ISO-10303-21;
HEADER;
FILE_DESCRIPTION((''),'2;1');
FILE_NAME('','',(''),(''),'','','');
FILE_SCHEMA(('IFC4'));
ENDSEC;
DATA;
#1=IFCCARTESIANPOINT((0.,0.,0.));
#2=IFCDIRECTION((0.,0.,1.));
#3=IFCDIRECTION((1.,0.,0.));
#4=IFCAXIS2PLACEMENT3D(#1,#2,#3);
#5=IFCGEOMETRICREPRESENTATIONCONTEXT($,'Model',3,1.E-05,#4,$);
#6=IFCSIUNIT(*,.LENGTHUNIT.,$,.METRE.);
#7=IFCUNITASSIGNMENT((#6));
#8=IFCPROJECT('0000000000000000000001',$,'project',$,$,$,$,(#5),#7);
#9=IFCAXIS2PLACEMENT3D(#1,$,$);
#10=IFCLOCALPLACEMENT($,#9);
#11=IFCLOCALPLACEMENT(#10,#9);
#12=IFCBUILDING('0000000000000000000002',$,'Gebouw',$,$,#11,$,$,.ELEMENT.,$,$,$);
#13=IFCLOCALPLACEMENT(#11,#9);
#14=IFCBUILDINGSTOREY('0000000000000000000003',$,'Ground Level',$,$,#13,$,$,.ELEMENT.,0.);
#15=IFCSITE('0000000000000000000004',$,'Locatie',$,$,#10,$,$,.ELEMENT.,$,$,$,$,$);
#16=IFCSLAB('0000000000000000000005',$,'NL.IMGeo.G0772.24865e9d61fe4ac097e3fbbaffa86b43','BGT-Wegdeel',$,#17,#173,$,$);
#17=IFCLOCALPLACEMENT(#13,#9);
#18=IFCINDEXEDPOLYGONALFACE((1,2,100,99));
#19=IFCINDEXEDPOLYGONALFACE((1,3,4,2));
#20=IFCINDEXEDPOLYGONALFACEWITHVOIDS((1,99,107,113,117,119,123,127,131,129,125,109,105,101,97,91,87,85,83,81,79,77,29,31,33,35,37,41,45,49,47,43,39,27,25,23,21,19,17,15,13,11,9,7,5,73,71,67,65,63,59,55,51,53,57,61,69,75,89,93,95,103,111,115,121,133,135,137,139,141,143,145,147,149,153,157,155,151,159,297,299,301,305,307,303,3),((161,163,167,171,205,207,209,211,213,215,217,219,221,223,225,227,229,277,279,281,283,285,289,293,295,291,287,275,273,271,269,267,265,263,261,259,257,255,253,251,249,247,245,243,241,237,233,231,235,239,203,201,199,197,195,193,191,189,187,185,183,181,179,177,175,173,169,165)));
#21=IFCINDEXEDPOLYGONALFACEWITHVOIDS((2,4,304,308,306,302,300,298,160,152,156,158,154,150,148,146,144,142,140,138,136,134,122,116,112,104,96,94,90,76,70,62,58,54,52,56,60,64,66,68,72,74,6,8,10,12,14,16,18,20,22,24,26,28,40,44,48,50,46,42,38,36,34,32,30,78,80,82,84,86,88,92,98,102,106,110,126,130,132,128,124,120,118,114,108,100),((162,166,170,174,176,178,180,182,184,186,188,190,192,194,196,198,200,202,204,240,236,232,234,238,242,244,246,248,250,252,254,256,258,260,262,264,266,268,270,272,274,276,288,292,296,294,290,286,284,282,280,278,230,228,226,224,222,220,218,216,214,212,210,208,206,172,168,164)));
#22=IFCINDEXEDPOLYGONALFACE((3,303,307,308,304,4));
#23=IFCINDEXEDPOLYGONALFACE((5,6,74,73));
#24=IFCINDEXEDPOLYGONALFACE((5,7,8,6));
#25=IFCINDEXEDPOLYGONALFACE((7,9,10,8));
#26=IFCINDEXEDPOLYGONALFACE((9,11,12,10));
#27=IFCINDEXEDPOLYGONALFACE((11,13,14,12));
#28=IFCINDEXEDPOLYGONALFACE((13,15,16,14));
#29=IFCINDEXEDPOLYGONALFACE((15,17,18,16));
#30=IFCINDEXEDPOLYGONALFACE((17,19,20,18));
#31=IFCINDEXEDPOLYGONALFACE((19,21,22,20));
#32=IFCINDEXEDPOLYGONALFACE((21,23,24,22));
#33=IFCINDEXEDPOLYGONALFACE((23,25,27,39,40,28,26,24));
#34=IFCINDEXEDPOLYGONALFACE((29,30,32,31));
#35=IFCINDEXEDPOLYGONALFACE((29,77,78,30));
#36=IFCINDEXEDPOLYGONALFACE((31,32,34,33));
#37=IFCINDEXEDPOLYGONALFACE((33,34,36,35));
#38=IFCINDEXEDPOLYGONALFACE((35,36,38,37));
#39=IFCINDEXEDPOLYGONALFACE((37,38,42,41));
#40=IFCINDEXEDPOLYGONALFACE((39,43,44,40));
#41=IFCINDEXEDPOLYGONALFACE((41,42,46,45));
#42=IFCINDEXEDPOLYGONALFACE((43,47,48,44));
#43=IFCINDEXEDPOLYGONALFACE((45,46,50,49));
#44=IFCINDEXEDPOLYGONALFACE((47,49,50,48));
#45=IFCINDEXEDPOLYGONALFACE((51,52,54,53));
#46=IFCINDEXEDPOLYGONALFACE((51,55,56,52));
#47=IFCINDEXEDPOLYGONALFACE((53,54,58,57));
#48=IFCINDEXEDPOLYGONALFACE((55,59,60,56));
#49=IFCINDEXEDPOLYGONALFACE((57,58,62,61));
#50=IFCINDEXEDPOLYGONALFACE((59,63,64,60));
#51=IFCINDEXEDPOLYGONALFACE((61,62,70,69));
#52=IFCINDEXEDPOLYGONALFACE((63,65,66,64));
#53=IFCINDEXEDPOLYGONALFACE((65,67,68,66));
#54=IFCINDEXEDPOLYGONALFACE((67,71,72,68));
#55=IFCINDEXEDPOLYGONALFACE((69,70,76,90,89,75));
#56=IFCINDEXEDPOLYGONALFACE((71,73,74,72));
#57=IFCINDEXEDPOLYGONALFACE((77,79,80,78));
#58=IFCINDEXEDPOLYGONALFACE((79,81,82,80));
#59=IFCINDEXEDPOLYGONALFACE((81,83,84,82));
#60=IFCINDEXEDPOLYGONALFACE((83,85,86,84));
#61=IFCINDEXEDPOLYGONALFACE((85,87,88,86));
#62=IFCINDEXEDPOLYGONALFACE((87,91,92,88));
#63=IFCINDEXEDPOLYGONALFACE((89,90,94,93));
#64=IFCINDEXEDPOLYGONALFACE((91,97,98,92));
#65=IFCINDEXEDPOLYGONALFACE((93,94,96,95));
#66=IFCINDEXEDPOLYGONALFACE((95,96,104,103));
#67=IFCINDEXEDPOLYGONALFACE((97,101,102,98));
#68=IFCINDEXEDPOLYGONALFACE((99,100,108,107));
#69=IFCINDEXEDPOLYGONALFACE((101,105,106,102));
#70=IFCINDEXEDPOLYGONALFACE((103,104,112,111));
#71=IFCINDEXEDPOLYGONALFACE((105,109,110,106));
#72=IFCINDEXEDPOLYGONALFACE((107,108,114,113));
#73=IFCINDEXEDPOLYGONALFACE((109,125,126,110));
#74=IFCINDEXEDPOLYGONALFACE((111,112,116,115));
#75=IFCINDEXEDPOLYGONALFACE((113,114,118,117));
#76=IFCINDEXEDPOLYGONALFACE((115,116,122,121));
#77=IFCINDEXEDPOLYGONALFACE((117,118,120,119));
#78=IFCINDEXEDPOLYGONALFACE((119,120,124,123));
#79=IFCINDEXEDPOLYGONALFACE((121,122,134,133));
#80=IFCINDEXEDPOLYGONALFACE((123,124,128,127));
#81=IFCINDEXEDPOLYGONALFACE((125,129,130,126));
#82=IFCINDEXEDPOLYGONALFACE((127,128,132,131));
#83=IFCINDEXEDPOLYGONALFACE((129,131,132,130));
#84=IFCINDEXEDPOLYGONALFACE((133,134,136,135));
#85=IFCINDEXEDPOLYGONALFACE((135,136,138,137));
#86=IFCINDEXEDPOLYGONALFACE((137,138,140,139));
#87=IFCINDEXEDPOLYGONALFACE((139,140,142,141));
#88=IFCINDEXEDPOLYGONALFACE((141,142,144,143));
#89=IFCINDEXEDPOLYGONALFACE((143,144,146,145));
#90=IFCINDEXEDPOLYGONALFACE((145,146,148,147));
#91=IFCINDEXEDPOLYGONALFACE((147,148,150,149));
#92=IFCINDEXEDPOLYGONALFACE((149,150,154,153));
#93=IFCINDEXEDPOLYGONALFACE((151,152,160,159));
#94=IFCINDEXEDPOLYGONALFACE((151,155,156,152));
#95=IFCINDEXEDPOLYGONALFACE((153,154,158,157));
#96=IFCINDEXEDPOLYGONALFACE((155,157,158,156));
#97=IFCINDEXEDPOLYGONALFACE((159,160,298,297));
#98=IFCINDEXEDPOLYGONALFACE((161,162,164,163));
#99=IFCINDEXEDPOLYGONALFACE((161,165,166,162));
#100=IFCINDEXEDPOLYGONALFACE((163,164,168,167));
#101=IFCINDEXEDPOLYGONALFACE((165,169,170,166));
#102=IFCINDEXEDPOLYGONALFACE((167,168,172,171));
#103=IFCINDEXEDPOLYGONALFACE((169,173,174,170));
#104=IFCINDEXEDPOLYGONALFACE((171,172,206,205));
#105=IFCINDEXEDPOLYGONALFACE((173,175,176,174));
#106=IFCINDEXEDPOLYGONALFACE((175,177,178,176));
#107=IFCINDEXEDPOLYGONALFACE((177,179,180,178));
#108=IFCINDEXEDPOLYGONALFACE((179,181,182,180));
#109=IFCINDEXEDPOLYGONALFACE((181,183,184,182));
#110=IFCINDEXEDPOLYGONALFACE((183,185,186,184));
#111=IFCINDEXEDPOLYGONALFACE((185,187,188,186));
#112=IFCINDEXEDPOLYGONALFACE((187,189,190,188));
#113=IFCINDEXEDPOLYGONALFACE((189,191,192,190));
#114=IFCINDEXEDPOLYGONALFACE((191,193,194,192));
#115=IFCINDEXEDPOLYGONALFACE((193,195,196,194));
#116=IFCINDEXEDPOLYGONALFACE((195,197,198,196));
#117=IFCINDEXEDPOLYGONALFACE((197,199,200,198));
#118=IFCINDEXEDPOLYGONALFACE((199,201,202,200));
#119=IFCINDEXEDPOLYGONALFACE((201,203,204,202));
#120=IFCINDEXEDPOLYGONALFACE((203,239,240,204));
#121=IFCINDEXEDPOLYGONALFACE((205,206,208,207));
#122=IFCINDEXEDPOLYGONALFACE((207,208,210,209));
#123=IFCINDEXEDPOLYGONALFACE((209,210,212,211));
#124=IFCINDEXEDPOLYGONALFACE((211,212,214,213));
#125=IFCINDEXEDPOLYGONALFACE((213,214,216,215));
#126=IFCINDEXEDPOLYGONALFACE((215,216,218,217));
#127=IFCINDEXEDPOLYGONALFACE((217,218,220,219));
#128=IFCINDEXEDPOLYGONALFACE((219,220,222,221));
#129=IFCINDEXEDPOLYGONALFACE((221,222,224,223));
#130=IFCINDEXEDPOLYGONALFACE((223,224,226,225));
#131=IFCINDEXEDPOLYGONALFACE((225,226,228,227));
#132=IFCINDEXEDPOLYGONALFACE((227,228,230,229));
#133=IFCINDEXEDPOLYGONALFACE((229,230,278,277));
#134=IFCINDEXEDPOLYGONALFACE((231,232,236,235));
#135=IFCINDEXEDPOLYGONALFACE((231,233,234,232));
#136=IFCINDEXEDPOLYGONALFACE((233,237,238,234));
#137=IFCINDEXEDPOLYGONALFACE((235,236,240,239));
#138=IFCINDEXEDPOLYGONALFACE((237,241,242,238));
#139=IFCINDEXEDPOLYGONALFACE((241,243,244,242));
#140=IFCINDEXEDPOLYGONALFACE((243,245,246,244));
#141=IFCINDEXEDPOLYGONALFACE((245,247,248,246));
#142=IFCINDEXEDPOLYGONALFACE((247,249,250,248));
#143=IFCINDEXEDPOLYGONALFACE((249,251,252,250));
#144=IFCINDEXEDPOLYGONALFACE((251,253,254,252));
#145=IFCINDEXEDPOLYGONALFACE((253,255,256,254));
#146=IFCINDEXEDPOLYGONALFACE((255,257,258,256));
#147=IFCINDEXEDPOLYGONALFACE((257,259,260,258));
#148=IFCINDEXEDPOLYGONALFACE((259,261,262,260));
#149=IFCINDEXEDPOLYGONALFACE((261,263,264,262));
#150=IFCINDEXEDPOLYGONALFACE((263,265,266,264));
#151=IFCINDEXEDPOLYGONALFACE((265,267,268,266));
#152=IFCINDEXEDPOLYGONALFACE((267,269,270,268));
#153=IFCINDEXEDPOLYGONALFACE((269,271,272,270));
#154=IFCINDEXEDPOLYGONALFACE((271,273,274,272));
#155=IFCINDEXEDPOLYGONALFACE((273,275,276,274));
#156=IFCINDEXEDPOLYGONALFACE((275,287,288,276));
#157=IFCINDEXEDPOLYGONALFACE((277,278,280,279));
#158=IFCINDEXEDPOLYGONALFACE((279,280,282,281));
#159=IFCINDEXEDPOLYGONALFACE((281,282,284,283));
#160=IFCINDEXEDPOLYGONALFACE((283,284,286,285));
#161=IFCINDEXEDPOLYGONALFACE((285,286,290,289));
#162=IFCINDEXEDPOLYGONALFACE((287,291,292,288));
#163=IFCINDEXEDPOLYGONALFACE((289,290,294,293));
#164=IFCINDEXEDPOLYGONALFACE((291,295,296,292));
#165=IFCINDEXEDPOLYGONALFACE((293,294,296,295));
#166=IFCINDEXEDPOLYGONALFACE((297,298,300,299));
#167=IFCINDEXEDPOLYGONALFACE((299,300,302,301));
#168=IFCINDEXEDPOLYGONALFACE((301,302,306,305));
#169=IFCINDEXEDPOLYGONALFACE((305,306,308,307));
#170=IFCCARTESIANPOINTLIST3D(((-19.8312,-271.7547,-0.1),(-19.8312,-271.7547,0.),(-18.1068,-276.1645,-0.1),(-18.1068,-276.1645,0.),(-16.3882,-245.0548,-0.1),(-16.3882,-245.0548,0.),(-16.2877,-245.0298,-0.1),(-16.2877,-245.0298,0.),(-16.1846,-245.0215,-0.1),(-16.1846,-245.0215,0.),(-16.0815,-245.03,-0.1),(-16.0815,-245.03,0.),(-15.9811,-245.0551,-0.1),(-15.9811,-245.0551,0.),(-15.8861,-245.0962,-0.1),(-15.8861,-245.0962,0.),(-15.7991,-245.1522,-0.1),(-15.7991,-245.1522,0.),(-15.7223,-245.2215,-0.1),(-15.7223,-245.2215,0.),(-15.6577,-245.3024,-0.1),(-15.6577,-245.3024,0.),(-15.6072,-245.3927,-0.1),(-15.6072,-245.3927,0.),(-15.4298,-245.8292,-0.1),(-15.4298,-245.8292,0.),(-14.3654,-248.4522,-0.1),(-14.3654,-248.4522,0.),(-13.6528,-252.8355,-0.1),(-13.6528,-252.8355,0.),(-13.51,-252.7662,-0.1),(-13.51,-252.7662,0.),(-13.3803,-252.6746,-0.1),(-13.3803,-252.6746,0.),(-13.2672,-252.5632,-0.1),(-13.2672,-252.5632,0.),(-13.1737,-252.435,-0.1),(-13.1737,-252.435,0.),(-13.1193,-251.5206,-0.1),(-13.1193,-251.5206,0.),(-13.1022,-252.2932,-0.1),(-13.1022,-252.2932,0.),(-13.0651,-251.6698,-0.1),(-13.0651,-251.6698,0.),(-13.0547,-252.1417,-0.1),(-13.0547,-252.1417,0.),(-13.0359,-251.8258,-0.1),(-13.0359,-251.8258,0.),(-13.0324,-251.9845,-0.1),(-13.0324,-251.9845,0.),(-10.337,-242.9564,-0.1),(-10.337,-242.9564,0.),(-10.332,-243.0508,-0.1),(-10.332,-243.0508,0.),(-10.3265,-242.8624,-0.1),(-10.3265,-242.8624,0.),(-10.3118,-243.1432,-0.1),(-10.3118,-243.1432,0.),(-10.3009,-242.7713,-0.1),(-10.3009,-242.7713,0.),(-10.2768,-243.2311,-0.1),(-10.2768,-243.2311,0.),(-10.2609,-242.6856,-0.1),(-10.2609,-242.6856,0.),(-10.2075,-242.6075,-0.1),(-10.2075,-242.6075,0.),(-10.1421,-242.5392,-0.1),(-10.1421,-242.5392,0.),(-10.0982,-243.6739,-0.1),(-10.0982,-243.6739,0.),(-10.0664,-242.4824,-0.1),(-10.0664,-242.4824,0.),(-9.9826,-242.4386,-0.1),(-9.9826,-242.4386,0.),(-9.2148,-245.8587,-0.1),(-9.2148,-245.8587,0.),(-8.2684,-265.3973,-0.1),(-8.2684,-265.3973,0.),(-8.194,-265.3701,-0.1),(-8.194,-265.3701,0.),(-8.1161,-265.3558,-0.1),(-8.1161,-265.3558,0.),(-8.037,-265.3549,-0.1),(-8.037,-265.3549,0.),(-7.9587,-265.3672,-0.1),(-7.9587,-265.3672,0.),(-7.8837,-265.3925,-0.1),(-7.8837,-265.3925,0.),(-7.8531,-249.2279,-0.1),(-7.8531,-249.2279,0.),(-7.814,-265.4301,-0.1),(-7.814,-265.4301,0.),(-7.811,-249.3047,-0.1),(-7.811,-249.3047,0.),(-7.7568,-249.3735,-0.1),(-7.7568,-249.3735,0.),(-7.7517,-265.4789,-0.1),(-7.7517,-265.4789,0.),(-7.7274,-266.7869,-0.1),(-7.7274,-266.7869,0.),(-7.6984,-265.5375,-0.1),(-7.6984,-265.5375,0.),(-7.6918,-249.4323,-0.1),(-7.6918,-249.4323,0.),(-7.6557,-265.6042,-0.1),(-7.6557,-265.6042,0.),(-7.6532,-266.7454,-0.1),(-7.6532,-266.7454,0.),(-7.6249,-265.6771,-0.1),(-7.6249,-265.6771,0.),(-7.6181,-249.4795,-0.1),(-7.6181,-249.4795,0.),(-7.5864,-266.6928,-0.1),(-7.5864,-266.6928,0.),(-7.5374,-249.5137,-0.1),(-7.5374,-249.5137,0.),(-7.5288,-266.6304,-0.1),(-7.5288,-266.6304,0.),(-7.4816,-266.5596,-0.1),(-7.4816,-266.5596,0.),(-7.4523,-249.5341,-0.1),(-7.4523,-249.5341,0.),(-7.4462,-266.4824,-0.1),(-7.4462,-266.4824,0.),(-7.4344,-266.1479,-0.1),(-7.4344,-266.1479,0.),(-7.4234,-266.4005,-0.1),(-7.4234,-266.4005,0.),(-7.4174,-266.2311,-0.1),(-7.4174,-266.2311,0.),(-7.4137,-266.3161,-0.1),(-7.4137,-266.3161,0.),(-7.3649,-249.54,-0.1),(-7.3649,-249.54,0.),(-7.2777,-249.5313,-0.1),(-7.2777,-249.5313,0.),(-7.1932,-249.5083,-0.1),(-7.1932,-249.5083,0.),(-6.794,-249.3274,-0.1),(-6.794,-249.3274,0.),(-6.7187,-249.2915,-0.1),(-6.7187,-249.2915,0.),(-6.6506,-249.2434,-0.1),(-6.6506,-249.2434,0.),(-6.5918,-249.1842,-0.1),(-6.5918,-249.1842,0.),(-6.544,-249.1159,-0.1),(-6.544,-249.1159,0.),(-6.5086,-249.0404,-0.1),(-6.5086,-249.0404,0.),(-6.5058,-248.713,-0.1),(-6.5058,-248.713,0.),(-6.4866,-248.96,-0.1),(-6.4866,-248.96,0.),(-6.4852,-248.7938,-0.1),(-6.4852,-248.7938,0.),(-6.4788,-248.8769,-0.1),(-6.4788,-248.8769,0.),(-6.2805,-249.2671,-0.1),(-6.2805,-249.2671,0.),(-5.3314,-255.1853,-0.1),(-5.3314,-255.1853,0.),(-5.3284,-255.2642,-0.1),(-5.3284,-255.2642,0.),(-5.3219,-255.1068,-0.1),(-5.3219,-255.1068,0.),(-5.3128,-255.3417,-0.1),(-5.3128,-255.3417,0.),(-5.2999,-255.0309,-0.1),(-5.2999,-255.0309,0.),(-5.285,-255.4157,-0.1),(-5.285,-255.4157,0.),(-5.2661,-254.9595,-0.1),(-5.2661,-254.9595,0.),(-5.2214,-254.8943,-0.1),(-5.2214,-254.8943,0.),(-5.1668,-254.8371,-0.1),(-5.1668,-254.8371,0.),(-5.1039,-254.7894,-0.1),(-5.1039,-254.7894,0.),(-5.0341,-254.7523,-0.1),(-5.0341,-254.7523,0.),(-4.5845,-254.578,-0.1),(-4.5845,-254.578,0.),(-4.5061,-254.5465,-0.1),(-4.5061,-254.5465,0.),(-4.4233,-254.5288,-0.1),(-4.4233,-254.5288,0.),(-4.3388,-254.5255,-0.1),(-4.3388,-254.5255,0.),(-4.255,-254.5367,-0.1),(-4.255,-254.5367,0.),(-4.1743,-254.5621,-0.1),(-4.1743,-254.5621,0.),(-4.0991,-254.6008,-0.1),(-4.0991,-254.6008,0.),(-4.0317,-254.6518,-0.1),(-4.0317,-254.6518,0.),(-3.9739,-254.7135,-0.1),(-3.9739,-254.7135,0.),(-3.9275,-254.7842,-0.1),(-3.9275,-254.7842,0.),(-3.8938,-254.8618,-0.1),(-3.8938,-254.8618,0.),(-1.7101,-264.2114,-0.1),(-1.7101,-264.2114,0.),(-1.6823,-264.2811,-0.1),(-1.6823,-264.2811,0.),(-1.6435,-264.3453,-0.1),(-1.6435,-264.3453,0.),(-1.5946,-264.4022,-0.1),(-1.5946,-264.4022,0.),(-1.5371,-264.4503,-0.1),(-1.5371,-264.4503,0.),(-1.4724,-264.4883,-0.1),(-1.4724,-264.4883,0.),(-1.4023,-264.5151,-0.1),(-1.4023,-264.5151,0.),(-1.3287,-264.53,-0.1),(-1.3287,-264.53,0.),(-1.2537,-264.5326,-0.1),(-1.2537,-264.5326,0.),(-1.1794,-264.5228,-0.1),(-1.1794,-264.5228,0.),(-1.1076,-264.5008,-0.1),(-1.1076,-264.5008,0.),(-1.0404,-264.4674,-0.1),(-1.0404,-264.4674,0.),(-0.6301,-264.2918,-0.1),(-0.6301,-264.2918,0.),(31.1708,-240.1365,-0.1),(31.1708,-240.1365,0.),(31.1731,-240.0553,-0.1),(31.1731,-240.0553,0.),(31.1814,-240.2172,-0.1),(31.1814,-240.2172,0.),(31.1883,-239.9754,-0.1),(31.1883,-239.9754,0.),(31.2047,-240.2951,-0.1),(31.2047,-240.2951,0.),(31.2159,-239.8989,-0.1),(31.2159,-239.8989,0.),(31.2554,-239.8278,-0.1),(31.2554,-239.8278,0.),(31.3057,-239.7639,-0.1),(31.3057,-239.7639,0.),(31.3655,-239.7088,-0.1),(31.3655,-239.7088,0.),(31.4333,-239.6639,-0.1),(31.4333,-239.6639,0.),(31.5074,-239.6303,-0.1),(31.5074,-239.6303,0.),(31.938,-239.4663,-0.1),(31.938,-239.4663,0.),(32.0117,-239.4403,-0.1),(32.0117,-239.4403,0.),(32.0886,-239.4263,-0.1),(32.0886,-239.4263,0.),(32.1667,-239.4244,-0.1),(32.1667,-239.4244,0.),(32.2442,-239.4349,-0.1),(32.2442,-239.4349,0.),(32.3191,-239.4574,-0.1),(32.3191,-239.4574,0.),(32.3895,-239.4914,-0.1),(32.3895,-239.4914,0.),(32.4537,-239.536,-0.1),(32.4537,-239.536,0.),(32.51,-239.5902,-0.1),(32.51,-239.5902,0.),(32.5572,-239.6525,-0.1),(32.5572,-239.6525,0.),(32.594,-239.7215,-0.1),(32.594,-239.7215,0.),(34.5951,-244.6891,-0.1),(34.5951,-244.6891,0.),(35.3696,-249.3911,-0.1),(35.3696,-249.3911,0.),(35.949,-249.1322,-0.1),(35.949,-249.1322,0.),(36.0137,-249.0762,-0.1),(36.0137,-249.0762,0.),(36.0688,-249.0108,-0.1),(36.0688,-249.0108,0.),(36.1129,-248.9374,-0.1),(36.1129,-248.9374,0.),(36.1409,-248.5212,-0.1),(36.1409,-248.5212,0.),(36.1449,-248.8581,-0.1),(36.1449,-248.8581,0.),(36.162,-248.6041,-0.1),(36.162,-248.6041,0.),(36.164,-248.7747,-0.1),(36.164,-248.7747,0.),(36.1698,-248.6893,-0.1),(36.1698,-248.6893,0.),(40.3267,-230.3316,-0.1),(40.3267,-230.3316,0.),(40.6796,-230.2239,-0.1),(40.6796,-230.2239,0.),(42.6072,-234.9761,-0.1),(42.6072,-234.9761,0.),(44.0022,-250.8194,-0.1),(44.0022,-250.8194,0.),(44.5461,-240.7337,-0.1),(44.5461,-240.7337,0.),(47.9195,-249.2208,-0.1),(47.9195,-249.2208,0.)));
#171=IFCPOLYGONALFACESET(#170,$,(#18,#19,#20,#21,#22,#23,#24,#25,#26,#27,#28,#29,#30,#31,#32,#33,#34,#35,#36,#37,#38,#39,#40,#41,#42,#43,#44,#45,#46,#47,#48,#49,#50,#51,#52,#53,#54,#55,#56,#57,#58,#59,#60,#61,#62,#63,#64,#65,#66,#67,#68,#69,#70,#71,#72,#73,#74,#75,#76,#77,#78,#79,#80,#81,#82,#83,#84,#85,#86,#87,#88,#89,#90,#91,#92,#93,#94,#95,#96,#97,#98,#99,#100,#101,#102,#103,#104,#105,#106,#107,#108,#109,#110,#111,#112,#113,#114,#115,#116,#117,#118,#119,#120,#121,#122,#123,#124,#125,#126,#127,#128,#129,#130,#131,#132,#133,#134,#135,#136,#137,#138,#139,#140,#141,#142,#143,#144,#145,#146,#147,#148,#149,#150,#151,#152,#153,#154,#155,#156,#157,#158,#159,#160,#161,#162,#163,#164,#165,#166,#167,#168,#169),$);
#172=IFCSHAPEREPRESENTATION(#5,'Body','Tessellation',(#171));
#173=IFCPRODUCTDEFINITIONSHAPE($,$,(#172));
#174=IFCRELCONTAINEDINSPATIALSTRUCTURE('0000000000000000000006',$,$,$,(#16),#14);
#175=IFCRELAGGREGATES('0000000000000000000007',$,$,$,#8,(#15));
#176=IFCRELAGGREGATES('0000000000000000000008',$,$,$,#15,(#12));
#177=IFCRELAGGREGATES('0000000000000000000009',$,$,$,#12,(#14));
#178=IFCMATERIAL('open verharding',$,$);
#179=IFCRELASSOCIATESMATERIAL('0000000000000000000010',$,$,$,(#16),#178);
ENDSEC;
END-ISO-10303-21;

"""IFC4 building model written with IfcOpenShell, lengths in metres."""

from ifc_helpers import new_model, si_unit, frame, origin, origin_with_axes, place, context, project, spatial, polyline, outline, extrude, material, element, save


model = new_model("IFC4")

# Units and contexts
model_context = context("Model", 3, precision=1e-05, world=origin_with_axes())
ifc_project = project(units=[si_unit("LENGTHUNIT", "METRE")], contexts=[model_context])

# Site, building, storey
site_placement = place(None, origin())
site = spatial("IfcSite", under=ifc_project, at=site_placement, Name="Locatie", CompositionType="ELEMENT")
building_placement = place(site_placement, origin())
building = spatial("IfcBuilding", under=site, at=building_placement, Name="Gebouw", CompositionType="ELEMENT")
storey_placement = place(building_placement, origin())
storey = spatial("IfcBuildingStorey", under=building, at=storey_placement, Name="Ground Level", CompositionType="ELEMENT", Elevation=0.0)

# Slab
ifc_material = material(Name="open verharding")
slab_1_placement = place(storey_placement, origin())
element("IfcSlab", 1, at=slab_1_placement, inside=storey, material=ifc_material, Name="NL.IMGeo.G0772.24865e9d61fe4ac097e3fbbaffa86b43", Description="BGT-Wegdeel", context=model_context, shape_type="SweptSolid", body=[
    extrude(outline(polyline([(-6.2805, -249.2671), (40.3267, -230.3316), (40.6796, -230.2239), (42.6072, -234.9761), (44.5461, -240.7337), (47.9195, -249.2208), (44.0022, -250.8194), (-18.1068, -276.1645), (-19.8312, -271.7547), (-7.7274, -266.7869), (-7.6532, -266.7454), (-7.5864, -266.6928), (-7.5288, -266.6304), (-7.4816, -266.5596), (-7.4462, -266.4824), (-7.4234, -266.4005), (-7.4137, -266.3161), (-7.4174, -266.2311), (-7.4344, -266.1479), (-7.6249, -265.6771), (-7.6557, -265.6042), (-7.6984, -265.5375), (-7.7517, -265.4789), (-7.814, -265.4301), (-7.8837, -265.3925), (-7.9587, -265.3672), (-8.037, -265.3549), (-8.1161, -265.3558), (-8.194, -265.3701), (-8.2684, -265.3973), (-13.6528, -252.8355), (-13.51, -252.7662), (-13.3803, -252.6746), (-13.2672, -252.5632), (-13.1737, -252.435), (-13.1022, -252.2932), (-13.0547, -252.1417), (-13.0324, -251.9845), (-13.0359, -251.8258), (-13.0651, -251.6698), (-13.1193, -251.5206), (-14.3654, -248.4522), (-15.4298, -245.8292), (-15.6072, -245.3927), (-15.6577, -245.3024), (-15.7223, -245.2215), (-15.7991, -245.1522), (-15.8861, -245.0962), (-15.9811, -245.0551), (-16.0815, -245.03), (-16.1846, -245.0215), (-16.2877, -245.0298), (-16.3882, -245.0548), (-9.9826, -242.4386), (-10.0664, -242.4824), (-10.1421, -242.5392), (-10.2075, -242.6075), (-10.2609, -242.6856), (-10.3009, -242.7713), (-10.3265, -242.8624), (-10.337, -242.9564), (-10.332, -243.0508), (-10.3118, -243.1432), (-10.2768, -243.2311), (-10.0982, -243.6739), (-9.2148, -245.8587), (-7.8531, -249.2279), (-7.811, -249.3047), (-7.7568, -249.3735), (-7.6918, -249.4323), (-7.6181, -249.4795), (-7.5374, -249.5137), (-7.4523, -249.5341), (-7.3649, -249.54), (-7.2777, -249.5313), (-7.1932, -249.5083), (-6.794, -249.3274), (-6.7187, -249.2915), (-6.6506, -249.2434), (-6.5918, -249.1842), (-6.544, -249.1159), (-6.5086, -249.0404), (-6.4866, -248.96), (-6.4788, -248.8769), (-6.4852, -248.7938), (-6.5058, -248.713), (-6.2805, -249.2671)]), holes=[polyline([(34.5951, -244.6891), (32.594, -239.7215), (32.5572, -239.6525), (32.51, -239.5902), (32.4537, -239.536), (32.3895, -239.4914), (32.3191, -239.4574), (32.2442, -239.4349), (32.1667, -239.4244), (32.0886, -239.4263), (32.0117, -239.4403), (31.938, -239.4663), (31.5074, -239.6303), (31.4333, -239.6639), (31.3655, -239.7088), (31.3057, -239.7639), (31.2554, -239.8278), (31.2159, -239.8989), (31.1883, -239.9754), (31.1731, -240.0553), (31.1708, -240.1365), (31.1814, -240.2172), (31.2047, -240.2951), (-3.8938, -254.8618), (-3.9275, -254.7842), (-3.9739, -254.7135), (-4.0317, -254.6518), (-4.0991, -254.6008), (-4.1743, -254.5621), (-4.255, -254.5367), (-4.3388, -254.5255), (-4.4233, -254.5288), (-4.5061, -254.5465), (-4.5845, -254.578), (-5.0341, -254.7523), (-5.1039, -254.7894), (-5.1668, -254.8371), (-5.2214, -254.8943), (-5.2661, -254.9595), (-5.2999, -255.0309), (-5.3219, -255.1068), (-5.3314, -255.1853), (-5.3284, -255.2642), (-5.3128, -255.3417), (-5.285, -255.4157), (-1.7101, -264.2114), (-1.6823, -264.2811), (-1.6435, -264.3453), (-1.5946, -264.4022), (-1.5371, -264.4503), (-1.4724, -264.4883), (-1.4023, -264.5151), (-1.3287, -264.53), (-1.2537, -264.5326), (-1.1794, -264.5228), (-1.1076, -264.5008), (-1.0404, -264.4674), (-0.6301, -264.2918), (35.3696, -249.3911), (35.949, -249.1322), (36.0137, -249.0762), (36.0688, -249.0108), (36.1129, -248.9374), (36.1449, -248.8581), (36.164, -248.7747), (36.1698, -248.6893), (36.162, -248.6041), (36.1409, -248.5212), (34.5951, -244.6891)])]), frame((0.0, 0.0, -0.1), z_axis=(0.0, 0.0, 1.0), x_axis=(1.0, 0.0, 0.0)), (0.0, 0.0, 1.0), 0.1),
])

save(model, "model.ifc")
